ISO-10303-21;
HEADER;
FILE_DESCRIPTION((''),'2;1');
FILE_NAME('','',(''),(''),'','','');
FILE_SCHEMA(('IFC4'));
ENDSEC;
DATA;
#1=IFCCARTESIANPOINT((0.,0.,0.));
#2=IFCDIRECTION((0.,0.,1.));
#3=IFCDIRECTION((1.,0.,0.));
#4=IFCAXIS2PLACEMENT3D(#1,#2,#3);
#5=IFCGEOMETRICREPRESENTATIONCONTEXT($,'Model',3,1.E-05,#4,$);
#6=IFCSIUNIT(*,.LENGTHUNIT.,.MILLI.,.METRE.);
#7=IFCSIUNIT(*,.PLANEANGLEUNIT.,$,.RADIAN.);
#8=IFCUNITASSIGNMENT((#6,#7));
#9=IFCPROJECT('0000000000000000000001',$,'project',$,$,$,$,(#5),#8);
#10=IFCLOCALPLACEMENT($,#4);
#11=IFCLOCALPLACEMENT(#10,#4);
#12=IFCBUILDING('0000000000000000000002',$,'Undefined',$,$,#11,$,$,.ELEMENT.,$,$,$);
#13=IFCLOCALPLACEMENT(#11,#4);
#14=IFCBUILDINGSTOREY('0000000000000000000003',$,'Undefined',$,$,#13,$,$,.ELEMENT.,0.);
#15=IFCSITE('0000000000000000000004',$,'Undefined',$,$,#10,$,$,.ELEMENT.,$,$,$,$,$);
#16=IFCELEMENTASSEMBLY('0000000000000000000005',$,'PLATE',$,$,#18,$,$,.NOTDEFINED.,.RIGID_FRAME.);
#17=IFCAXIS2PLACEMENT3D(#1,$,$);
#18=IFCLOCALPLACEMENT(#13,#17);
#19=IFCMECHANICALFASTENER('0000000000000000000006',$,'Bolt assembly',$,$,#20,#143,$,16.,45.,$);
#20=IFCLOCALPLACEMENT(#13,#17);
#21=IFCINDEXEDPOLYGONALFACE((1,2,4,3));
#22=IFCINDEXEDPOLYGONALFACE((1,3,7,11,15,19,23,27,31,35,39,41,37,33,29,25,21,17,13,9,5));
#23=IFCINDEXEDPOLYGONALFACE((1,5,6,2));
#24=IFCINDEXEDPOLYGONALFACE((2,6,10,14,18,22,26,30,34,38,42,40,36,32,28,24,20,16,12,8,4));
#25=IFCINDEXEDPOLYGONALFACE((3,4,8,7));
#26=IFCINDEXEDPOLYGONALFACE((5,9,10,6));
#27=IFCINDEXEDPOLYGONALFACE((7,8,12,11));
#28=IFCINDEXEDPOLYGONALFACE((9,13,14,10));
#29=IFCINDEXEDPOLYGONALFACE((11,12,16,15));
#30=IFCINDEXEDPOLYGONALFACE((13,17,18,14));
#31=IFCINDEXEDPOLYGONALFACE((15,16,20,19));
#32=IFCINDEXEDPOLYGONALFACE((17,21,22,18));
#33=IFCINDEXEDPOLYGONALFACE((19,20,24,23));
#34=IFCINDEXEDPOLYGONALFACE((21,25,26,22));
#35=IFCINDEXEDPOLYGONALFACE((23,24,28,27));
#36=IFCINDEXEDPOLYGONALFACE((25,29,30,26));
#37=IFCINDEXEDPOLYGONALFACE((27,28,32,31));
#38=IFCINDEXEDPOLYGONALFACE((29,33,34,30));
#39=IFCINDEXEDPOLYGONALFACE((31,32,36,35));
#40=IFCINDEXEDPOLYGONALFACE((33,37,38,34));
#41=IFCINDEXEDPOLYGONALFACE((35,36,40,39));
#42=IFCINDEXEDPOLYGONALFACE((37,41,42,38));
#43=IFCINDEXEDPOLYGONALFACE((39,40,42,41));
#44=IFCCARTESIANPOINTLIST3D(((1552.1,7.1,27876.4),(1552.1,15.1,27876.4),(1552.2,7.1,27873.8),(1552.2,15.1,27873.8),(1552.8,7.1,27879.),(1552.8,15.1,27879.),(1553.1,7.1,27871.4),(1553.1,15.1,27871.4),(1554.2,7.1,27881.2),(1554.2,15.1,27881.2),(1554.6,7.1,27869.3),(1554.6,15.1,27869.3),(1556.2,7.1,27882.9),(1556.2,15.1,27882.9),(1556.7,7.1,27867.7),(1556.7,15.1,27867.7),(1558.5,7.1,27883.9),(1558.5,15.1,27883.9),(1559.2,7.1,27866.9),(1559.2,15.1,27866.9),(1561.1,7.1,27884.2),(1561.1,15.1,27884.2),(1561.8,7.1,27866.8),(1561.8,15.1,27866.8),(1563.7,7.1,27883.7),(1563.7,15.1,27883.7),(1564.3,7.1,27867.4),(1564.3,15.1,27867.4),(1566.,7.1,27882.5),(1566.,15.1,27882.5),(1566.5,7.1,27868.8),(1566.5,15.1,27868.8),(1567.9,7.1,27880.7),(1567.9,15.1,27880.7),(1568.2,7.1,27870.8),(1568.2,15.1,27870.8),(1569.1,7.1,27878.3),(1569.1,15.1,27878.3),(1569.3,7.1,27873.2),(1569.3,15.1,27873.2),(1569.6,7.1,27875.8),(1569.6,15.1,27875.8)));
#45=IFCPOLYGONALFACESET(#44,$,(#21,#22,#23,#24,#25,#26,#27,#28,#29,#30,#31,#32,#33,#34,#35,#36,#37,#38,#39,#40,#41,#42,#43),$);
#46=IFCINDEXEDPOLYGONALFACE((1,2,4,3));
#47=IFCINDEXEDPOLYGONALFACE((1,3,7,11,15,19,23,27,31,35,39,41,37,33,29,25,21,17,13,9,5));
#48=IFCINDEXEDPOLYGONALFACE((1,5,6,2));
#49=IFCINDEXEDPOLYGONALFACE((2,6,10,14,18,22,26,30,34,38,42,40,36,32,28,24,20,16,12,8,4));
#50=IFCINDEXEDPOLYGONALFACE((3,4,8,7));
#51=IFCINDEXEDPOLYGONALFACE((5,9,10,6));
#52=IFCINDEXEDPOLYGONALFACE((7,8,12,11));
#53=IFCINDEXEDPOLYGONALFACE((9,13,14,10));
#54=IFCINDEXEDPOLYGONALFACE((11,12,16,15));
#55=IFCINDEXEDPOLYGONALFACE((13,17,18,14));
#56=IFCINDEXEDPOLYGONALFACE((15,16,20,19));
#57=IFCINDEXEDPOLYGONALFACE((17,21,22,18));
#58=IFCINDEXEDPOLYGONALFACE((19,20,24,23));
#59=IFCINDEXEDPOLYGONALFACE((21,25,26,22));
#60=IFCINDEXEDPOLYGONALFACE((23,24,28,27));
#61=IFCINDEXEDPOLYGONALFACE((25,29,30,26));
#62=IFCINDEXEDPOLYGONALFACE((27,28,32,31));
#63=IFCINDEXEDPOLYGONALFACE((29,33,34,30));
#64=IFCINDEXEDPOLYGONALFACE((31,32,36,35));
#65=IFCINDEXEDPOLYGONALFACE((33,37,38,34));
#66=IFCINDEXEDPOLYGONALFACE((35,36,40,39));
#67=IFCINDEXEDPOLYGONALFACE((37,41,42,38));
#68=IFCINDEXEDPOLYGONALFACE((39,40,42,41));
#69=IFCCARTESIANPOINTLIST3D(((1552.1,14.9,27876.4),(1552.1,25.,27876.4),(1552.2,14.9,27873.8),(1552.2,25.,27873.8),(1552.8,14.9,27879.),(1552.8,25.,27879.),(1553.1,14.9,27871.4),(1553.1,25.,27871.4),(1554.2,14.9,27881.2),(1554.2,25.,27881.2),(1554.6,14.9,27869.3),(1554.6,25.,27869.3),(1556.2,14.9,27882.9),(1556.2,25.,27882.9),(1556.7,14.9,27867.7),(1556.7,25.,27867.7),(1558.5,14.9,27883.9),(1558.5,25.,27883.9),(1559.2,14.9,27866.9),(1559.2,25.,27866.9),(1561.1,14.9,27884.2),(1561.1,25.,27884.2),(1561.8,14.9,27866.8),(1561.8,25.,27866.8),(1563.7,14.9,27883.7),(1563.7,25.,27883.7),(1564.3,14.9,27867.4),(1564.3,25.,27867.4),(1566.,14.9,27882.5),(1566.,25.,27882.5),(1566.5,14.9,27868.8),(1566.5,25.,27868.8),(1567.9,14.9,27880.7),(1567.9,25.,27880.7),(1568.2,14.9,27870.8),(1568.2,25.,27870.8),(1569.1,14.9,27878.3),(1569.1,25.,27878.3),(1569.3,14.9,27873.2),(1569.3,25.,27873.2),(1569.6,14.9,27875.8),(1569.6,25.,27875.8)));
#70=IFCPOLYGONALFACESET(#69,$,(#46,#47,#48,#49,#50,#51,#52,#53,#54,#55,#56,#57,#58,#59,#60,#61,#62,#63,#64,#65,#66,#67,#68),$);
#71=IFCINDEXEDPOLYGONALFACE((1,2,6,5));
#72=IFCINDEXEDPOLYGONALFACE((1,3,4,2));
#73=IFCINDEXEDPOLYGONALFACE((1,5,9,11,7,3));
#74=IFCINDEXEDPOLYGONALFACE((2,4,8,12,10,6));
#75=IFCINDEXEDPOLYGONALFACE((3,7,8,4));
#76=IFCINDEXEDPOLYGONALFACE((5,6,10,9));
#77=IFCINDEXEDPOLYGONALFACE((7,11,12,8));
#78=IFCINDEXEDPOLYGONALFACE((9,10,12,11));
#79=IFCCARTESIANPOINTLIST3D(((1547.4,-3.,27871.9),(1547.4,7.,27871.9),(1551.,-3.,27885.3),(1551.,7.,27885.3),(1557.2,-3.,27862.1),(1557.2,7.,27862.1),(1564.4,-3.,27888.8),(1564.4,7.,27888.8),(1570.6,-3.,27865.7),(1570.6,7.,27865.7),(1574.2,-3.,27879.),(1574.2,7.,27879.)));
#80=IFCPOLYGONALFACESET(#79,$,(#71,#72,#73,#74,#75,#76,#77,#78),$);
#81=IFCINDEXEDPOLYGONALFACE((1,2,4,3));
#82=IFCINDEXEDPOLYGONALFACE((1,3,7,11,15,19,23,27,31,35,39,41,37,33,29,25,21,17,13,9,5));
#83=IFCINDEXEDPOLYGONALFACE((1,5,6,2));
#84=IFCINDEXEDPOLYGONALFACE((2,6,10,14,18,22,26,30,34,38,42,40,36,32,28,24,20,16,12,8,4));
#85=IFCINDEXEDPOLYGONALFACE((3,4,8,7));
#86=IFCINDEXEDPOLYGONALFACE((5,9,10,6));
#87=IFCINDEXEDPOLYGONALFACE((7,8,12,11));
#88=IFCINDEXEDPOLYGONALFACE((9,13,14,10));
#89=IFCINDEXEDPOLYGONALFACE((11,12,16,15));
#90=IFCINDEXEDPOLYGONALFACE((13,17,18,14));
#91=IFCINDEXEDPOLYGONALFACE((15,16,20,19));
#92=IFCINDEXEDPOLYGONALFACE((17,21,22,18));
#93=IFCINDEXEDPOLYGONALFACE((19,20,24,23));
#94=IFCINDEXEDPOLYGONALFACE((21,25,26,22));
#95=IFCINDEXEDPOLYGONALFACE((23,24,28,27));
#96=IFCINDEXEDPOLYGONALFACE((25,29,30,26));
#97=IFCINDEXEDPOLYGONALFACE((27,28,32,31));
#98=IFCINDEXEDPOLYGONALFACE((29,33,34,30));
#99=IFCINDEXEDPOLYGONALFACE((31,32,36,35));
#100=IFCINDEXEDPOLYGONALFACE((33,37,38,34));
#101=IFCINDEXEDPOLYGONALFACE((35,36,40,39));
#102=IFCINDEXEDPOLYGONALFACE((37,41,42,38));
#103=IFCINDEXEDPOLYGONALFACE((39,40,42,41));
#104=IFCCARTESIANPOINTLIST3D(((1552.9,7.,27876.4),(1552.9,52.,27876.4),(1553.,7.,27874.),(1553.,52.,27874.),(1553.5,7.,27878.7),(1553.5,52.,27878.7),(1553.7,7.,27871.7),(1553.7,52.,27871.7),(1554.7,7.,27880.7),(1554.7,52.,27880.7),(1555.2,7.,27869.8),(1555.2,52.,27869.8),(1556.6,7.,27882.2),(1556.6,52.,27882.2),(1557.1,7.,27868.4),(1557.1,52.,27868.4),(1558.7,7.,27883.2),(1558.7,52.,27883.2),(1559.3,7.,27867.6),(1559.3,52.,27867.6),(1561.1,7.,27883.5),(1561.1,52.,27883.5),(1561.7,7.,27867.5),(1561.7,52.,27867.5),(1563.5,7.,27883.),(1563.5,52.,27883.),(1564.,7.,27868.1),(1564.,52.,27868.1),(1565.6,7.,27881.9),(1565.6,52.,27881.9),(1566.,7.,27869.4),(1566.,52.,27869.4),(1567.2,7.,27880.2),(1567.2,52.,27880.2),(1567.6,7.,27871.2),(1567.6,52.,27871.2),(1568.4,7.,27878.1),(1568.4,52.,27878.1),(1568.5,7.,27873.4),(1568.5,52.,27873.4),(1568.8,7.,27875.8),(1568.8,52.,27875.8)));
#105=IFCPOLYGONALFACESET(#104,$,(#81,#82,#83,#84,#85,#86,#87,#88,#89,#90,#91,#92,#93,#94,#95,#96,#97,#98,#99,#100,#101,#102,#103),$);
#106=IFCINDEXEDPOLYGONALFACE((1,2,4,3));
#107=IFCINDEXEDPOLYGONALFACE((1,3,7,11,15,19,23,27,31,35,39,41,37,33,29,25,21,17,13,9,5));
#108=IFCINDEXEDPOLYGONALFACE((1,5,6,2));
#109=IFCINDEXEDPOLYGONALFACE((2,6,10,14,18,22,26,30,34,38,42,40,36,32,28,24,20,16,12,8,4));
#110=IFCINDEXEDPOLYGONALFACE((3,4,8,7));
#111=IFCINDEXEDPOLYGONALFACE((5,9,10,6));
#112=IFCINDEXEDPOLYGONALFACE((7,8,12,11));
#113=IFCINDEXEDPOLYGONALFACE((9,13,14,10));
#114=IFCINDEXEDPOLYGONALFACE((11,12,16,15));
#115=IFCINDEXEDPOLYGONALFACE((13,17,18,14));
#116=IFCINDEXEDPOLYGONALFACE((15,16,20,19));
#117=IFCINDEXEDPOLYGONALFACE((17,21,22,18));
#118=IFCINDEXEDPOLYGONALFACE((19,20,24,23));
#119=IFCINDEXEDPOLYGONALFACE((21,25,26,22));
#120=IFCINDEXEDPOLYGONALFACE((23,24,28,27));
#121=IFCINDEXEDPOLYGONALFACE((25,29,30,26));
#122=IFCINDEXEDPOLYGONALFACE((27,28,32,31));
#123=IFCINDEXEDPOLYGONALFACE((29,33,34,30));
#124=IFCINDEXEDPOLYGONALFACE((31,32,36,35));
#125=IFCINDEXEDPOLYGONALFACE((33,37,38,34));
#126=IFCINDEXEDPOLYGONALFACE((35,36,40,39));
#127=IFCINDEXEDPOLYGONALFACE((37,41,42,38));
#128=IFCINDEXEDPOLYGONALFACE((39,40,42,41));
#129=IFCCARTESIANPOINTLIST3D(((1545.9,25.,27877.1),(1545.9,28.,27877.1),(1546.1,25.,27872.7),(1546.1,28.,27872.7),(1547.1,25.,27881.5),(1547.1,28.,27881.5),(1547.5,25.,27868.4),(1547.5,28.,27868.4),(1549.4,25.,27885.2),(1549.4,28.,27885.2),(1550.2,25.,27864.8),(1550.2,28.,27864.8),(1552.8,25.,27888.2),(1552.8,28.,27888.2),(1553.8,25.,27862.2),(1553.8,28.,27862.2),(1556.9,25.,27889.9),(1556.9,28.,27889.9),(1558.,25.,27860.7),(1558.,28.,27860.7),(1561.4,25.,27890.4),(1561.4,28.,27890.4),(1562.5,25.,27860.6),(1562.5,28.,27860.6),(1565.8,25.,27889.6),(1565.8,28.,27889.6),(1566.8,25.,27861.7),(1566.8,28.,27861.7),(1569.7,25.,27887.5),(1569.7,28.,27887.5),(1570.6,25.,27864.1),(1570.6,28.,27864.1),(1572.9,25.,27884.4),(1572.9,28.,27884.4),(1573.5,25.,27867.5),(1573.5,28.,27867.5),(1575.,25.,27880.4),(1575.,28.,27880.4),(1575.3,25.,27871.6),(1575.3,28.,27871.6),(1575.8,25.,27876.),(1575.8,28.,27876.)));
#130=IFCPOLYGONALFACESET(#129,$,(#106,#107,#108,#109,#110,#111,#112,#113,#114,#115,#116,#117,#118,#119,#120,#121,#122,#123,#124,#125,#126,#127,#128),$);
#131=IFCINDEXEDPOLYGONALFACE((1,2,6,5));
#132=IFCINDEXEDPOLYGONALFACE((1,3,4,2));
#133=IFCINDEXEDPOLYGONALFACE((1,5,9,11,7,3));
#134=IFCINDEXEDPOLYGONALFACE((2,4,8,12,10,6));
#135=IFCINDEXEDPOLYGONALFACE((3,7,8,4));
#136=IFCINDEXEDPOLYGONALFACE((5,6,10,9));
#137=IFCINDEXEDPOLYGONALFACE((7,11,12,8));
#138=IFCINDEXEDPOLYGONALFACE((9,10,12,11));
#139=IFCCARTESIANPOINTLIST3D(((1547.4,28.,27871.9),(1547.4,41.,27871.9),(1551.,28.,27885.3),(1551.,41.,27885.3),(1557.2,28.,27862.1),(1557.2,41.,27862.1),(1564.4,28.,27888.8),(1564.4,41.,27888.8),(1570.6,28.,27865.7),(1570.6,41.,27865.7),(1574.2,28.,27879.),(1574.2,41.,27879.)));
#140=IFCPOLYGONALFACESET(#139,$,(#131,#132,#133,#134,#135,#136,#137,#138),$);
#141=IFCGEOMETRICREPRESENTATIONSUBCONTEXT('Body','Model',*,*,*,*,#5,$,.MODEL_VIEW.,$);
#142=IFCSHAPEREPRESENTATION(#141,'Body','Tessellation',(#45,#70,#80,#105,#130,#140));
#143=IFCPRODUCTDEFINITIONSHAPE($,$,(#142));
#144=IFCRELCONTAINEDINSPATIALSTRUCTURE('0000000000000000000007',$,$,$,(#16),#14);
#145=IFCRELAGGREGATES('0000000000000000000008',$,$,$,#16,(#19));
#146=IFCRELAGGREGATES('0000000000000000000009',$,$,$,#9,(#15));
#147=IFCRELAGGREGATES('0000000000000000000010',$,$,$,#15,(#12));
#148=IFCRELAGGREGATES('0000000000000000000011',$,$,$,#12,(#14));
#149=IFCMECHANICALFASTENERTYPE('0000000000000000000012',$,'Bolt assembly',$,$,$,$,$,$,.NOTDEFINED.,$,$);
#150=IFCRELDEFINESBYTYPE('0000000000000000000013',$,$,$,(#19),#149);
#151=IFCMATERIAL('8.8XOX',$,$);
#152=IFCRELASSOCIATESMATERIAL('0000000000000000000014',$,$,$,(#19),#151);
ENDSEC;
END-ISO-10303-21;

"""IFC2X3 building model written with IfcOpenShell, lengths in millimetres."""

from ifc_helpers import new_model, si_unit, frame, origin_with_axes, origin_2d_with_axis, place, context, subcontext, project, spatial, polyline, circle, outline, extrude, source, transform, mapped, material, type_object, element, aggregate, save


model = new_model("IFC2X3")

# Units and contexts
model_context = context("Model", 3, precision=1e-05, world=origin_with_axes())
body_context = subcontext(model_context, "Body", "Model", "MODEL_VIEW")
ifc_project = project(units=[si_unit("LENGTHUNIT", "METRE", prefix="MILLI"), si_unit("PLANEANGLEUNIT", "RADIAN")], contexts=[model_context])

# Site, building, storey
site_placement = place(None, origin_with_axes())
site = spatial("IfcSite", under=ifc_project, at=site_placement, Name="Undefined", CompositionType="ELEMENT")
building_placement = place(site_placement, origin_with_axes())
building = spatial("IfcBuilding", under=site, at=building_placement, Name="Undefined", CompositionType="ELEMENT")
storey_placement = place(building_placement, origin_with_axes())
storey = spatial("IfcBuildingStorey", under=building, at=storey_placement, Name="Undefined", CompositionType="ELEMENT", Elevation=0.0)

# Element assembly
assembly_1_placement = place(storey_placement, origin_with_axes())
assembly_1 = element("IfcElementAssembly", 1, at=assembly_1_placement, inside=storey, Name="PLATE", AssemblyPlace="NOTDEFINED", PredefinedType="RIGID_FRAME")

# Shared definitions
ifc_material_1 = material(Name="8.8XOX")
mechanical_fastener_type = type_object("IfcMechanicalFastenerType", Name="Bolt assembly")
shared_shape = source(origin_with_axes(), body_context, "Body", "SweptSolid", [
    extrude(circle(Radius=8.8, at=origin_2d_with_axis()), frame((0.0, 7.1, 0.0), z_axis=(0.0, 1.0, 0.0), x_axis=(1.0, 0.0, 0.0)), (0.0, 0.0, 1.0), 8.0),
    extrude(circle(Radius=8.8, at=origin_2d_with_axis()), frame((0.0, 14.9, 0.0), z_axis=(0.0, 1.0, 0.0), x_axis=(1.0, 0.0, 0.0)), (0.0, 0.0, 1.0), 10.1),
    extrude(outline(polyline([(12.0, -6.9), (12.0, 6.9), (0.0, 13.9), (-12.0, 6.9), (-12.0, -6.9), (0.0, -13.9), (12.0, -6.9)])), frame((0.0, -3.0, 0.0), z_axis=(0.0, 1.0, 0.0), x_axis=(1.0, 0.0, 0.0)), (0.0, 0.0, 1.0), 10.0),
    extrude(circle(Radius=8.0, at=origin_2d_with_axis()), frame((0.0, 7.0, 0.0), z_axis=(0.0, 1.0, 0.0), x_axis=(1.0, 0.0, 0.0)), (0.0, 0.0, 1.0), 45.0),
    extrude(circle(Radius=15.0, at=origin_2d_with_axis()), frame((0.0, 25.0, 0.0), z_axis=(0.0, 1.0, 0.0), x_axis=(1.0, 0.0, 0.0)), (0.0, 0.0, 1.0), 3.0),
    extrude(outline(polyline([(12.0, -6.9), (12.0, 6.9), (0.0, 13.9), (-12.0, 6.9), (-12.0, -6.9), (0.0, -13.9), (12.0, -6.9)])), frame((0.0, 28.0, 0.0), z_axis=(0.0, 1.0, 0.0), x_axis=(1.0, 0.0, 0.0)), (0.0, 0.0, 1.0), 13.0),
])

# Mechanical fastener
mechanical_fastener_1_placement = place(assembly_1_placement, frame((1560.8, 0.0, 27875.5), z_axis=(0.707107, 0.0, -0.707107), x_axis=(-0.707107, 0.0, -0.707107)))
mechanical_fastener_1 = element("IfcMechanicalFastener", 2, at=mechanical_fastener_1_placement, type_object=mechanical_fastener_type, material=ifc_material_1, Name="Bolt assembly", NominalDiameter=16.0, NominalLength=45.0, context=body_context, shape_type="MappedRepresentation", body=[
    mapped(shared_shape, transform((0.0, 0.0, 0.0))),
])
aggregate(assembly_1, [mechanical_fastener_1])

save(model, "model.ifc")
